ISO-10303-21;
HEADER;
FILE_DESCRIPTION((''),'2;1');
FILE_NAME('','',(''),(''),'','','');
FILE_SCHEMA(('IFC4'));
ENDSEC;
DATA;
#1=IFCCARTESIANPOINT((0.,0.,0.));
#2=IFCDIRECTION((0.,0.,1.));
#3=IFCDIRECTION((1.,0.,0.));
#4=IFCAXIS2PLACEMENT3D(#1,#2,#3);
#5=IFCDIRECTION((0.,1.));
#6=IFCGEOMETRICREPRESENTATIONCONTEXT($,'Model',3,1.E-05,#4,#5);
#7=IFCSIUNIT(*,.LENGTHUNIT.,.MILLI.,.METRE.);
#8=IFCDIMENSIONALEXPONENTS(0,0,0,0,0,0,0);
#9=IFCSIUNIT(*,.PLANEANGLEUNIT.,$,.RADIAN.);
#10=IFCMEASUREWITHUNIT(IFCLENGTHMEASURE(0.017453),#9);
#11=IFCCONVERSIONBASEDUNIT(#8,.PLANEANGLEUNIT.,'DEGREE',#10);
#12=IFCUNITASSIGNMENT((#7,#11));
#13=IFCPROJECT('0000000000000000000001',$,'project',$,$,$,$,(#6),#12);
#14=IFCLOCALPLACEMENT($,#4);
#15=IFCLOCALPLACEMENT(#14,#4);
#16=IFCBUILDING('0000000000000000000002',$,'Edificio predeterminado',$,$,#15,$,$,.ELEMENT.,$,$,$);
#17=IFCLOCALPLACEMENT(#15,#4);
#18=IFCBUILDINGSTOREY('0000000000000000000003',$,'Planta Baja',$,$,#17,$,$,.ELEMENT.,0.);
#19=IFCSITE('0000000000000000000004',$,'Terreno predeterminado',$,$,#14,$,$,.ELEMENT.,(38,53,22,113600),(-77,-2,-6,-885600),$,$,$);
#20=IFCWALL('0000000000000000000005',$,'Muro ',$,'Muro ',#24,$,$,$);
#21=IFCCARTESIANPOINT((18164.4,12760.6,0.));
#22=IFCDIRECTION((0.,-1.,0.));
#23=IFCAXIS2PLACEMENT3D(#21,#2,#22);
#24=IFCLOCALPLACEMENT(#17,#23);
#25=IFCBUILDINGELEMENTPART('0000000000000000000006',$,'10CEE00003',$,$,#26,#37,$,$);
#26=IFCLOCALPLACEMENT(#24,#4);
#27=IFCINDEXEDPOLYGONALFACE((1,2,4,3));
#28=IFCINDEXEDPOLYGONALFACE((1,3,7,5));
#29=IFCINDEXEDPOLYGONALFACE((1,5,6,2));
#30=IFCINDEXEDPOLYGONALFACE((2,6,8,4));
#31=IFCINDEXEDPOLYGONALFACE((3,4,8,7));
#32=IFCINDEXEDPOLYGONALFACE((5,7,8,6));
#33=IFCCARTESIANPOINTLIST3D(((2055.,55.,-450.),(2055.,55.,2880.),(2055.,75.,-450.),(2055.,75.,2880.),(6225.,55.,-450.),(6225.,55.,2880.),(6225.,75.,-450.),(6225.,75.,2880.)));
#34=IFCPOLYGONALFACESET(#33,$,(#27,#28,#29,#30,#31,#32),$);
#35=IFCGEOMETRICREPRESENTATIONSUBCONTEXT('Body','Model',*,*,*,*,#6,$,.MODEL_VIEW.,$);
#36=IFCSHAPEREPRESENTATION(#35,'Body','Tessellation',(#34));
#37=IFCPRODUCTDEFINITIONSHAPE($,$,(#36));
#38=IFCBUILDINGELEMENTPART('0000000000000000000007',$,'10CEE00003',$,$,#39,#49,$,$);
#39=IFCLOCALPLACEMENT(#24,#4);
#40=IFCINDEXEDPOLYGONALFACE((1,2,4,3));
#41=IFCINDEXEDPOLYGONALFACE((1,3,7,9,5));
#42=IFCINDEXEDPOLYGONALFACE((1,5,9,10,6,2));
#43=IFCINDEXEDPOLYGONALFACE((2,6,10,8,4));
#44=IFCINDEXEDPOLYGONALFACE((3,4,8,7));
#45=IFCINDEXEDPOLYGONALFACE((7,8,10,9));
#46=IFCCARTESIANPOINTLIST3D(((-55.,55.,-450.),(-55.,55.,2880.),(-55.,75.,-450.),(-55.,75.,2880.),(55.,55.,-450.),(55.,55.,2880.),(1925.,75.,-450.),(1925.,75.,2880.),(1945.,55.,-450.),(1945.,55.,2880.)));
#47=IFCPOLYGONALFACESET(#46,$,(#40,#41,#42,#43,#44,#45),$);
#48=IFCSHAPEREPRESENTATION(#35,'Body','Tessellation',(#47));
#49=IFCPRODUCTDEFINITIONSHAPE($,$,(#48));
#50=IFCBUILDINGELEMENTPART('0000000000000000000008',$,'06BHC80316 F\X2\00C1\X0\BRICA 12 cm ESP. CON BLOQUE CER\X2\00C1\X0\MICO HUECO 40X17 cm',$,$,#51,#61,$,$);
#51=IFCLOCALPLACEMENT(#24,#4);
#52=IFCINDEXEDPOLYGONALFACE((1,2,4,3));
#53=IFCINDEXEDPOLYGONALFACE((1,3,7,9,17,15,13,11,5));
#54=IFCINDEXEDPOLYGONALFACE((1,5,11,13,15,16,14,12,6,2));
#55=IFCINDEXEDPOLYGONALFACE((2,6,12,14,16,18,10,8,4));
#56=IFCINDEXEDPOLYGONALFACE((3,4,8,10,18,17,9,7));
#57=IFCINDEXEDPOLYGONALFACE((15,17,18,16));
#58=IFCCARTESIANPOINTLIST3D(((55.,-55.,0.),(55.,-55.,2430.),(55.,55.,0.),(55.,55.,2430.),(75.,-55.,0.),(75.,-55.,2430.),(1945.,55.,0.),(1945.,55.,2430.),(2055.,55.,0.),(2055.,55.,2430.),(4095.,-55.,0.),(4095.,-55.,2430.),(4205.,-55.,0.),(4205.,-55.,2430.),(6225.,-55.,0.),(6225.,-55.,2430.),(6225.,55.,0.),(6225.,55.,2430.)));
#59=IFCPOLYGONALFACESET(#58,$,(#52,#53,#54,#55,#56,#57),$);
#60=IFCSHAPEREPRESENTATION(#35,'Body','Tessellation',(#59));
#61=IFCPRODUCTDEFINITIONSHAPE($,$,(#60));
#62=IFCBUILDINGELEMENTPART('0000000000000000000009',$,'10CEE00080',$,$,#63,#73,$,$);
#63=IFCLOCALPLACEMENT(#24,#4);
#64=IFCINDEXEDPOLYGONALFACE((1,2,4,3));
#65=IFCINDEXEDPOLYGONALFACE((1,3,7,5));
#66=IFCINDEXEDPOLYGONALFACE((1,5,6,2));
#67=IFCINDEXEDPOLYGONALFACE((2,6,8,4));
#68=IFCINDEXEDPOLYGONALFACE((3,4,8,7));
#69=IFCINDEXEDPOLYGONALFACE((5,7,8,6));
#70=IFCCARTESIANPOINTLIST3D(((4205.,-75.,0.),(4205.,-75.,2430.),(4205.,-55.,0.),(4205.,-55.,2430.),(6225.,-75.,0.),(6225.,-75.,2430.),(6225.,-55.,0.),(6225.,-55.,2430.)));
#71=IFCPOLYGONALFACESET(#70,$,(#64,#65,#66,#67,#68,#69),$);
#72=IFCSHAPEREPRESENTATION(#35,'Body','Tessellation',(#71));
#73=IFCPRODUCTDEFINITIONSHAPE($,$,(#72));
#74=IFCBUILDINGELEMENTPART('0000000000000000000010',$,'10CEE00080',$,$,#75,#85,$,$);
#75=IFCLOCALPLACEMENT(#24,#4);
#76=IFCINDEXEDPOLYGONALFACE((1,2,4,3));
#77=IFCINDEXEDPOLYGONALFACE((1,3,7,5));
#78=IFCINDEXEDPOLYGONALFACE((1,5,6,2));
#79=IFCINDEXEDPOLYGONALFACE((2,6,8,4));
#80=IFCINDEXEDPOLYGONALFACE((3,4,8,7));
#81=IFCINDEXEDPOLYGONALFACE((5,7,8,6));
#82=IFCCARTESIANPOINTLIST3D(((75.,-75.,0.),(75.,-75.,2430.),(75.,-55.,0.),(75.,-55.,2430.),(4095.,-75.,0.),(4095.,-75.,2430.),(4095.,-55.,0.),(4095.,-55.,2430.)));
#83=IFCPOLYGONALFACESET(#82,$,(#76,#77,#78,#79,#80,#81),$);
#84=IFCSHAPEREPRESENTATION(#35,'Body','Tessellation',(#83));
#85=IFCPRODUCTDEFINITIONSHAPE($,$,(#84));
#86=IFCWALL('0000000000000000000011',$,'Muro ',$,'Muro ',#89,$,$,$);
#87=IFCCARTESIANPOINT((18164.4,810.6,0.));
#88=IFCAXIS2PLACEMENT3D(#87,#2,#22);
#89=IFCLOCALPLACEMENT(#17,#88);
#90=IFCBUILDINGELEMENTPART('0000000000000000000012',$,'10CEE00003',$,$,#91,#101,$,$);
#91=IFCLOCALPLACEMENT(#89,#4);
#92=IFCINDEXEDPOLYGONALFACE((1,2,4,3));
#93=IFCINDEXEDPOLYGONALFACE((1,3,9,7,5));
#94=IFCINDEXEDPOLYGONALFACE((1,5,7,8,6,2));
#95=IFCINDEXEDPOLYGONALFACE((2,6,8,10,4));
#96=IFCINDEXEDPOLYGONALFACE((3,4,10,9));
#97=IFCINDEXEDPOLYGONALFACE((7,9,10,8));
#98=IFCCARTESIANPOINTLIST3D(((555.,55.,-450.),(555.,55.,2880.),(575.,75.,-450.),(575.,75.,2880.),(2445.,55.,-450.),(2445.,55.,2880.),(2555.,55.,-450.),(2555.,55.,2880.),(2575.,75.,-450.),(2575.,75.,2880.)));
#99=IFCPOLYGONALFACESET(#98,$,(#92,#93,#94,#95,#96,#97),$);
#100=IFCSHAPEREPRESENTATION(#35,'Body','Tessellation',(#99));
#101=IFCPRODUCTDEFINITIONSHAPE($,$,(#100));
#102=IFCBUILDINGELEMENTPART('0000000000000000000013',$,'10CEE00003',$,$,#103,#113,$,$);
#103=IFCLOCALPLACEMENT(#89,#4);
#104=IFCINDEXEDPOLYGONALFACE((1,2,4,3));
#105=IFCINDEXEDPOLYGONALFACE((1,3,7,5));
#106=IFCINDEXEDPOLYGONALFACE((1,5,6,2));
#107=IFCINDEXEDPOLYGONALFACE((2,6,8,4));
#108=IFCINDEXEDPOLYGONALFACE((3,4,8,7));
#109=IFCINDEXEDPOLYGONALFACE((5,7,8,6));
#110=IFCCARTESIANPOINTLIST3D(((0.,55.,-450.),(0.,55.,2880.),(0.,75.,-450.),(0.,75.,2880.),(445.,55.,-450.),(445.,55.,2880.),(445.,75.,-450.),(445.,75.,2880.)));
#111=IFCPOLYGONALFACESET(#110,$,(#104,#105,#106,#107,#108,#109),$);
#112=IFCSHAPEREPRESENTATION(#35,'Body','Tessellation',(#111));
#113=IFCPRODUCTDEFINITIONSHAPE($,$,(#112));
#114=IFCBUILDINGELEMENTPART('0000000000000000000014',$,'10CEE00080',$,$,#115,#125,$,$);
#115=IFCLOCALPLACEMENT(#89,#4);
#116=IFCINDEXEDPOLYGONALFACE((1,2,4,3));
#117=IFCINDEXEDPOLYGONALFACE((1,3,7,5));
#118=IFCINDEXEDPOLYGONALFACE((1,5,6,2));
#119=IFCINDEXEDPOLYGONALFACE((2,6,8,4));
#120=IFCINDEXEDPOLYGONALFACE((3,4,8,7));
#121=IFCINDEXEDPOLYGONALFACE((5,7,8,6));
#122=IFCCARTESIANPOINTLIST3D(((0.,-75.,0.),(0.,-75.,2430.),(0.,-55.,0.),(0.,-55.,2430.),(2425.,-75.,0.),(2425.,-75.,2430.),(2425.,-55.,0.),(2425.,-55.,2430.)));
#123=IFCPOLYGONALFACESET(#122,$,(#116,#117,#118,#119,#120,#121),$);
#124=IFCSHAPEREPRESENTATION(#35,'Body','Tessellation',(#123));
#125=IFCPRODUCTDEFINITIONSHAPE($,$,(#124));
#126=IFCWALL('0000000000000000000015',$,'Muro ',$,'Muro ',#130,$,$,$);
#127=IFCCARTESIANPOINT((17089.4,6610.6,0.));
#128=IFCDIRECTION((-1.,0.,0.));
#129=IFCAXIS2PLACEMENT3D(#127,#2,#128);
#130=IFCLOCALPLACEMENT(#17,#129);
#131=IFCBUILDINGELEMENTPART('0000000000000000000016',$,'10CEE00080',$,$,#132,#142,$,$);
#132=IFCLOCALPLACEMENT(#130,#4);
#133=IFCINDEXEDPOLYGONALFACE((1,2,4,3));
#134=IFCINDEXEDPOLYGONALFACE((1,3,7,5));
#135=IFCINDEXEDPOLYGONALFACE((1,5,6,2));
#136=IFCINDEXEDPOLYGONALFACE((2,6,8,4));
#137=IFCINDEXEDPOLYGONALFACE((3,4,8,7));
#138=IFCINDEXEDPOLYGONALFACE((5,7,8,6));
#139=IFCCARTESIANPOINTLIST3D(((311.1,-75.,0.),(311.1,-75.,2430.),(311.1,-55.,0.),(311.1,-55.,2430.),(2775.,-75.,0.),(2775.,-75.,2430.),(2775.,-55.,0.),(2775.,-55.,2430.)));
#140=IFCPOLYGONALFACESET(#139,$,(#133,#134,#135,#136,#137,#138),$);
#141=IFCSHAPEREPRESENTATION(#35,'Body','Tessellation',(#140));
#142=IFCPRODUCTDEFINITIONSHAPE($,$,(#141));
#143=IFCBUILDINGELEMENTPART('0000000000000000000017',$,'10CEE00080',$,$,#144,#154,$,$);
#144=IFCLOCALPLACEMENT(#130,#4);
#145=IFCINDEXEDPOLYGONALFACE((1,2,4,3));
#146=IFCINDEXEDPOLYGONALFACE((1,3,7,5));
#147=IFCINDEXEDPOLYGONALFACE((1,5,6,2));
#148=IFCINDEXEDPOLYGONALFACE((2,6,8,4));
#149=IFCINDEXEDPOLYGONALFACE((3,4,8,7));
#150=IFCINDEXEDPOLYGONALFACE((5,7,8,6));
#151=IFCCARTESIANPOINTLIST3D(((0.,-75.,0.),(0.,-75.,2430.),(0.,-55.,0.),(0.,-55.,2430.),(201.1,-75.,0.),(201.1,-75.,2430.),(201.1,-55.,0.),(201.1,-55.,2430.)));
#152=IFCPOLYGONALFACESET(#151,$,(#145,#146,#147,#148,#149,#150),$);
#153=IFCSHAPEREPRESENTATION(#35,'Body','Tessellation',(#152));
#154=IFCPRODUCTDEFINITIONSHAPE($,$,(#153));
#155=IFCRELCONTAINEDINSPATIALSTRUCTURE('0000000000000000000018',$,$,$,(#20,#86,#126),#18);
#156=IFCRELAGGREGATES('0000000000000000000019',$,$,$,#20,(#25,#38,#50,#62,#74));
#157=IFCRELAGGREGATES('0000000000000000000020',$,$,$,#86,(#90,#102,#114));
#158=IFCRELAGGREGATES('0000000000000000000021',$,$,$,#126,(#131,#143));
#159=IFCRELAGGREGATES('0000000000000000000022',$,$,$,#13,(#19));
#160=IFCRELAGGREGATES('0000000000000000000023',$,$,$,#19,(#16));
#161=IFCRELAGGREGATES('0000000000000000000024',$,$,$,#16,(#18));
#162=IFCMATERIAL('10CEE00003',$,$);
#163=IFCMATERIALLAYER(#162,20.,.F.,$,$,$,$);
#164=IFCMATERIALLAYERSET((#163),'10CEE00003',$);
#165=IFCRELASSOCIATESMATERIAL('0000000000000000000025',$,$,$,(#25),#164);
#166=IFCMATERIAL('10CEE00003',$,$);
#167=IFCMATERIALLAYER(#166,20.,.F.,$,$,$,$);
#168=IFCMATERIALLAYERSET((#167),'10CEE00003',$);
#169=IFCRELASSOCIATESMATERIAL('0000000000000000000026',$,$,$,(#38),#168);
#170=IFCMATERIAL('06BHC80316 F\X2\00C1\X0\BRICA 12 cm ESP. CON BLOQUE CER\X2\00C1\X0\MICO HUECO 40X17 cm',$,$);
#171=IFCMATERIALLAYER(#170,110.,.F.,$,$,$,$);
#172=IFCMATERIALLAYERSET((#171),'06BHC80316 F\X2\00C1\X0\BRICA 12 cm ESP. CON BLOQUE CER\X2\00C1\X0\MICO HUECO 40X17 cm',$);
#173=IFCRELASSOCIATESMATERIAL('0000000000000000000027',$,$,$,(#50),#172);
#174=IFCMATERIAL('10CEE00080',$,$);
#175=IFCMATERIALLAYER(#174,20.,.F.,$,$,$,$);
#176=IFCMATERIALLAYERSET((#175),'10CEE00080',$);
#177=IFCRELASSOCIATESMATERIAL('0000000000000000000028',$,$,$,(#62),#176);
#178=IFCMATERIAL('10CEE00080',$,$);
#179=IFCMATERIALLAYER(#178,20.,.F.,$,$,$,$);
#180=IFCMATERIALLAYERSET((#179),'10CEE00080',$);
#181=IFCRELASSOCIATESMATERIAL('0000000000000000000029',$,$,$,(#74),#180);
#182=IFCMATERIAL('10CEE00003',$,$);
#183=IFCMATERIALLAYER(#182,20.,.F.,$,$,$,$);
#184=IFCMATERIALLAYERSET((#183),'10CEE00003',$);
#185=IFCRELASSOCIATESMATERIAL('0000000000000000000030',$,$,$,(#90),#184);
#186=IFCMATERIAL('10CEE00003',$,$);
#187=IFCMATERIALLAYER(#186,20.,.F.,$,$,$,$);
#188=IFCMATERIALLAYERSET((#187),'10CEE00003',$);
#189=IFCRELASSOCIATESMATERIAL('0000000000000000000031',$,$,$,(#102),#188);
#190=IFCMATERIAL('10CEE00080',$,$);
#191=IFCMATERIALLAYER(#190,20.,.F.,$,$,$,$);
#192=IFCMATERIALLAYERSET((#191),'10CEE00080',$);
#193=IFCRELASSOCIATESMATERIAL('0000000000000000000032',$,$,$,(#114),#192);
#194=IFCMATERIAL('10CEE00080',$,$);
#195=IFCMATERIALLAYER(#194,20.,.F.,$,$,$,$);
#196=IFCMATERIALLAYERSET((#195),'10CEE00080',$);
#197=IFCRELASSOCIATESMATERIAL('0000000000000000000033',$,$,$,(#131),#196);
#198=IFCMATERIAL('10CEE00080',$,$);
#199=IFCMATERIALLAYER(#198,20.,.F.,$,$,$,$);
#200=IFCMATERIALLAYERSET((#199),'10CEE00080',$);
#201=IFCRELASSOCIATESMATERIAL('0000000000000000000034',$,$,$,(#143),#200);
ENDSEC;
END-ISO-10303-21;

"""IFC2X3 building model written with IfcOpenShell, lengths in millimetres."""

from ifc_helpers import new_model, entity, si_unit, converted_unit, direction, frame, origin_with_axes, place, context, subcontext, project, spatial, polyline, outline, extrude, material, layer, layer_set, layer_usage, element, aggregate, save


model = new_model("IFC2X3")

# Units and contexts
model_context = context("Model", 3, precision=1e-05, world=origin_with_axes(), true_north=direction((0.0, 1.0)))
body_context = subcontext(model_context, "Body", "Model", "MODEL_VIEW")
ifc_project = project(units=[si_unit("LENGTHUNIT", "METRE", prefix="MILLI"), converted_unit("PLANEANGLEUNIT", "DEGREE", entity("IfcLengthMeasure", 0.017453), si_unit("PLANEANGLEUNIT", "RADIAN"), dimensions=[0, 0, 0, 0, 0, 0, 0])], contexts=[model_context])

# Site, building, storey
site_placement = place(None, origin_with_axes())
site = spatial("IfcSite", under=ifc_project, at=site_placement, Name="Terreno predeterminado", CompositionType="ELEMENT", RefLatitude=(38, 53, 22, 113600), RefLongitude=(-77, -2, -6, -885600))
building_placement = place(site_placement, origin_with_axes())
building = spatial("IfcBuilding", under=site, at=building_placement, Name="Edificio predeterminado", CompositionType="ELEMENT")
storey_placement = place(building_placement, origin_with_axes())
storey = spatial("IfcBuildingStorey", under=building, at=storey_placement, Name="Planta Baja", CompositionType="ELEMENT", Elevation=0.0)

# Walls, building element parts
wall_1_placement = place(storey_placement, frame((18164.4, 12760.6, 0.0), z_axis=(0.0, 0.0, 1.0), x_axis=(0.0, -1.0, 0.0)))
wall_1 = element("IfcWall", 1, at=wall_1_placement, inside=storey, Name="Muro ", ObjectType="Muro ")
ifc_material_1 = material(Name="10CEE00003")
ifc_layer_1 = layer(ifc_material_1, 20.0, ventilated=False)
ifc_layer_set_1 = layer_set([ifc_layer_1], Name="10CEE00003")
ifc_layer_usage_1 = layer_usage(ifc_layer_set_1, "AXIS2", "NEGATIVE", -75.0)
building_element_part_1_placement = place(wall_1_placement, origin_with_axes())
building_element_part_1 = element("IfcBuildingElementPart", 2, at=building_element_part_1_placement, material=ifc_layer_usage_1, Name="10CEE00003", context=body_context, shape_type="SweptSolid", body=[
    extrude(outline(polyline([(6225.0, 75.0), (6225.0, 55.0), (2055.0, 55.0), (2055.0, 75.0), (6225.0, 75.0)])), frame((0.0, 0.0, -450.0), z_axis=(0.0, 0.0, 1.0), x_axis=(1.0, 0.0, 0.0)), (0.0, 0.0, 1.0), 3330.0),
])
ifc_material_2 = material(Name="10CEE00003")
ifc_layer_2 = layer(ifc_material_2, 20.0, ventilated=False)
ifc_layer_set_2 = layer_set([ifc_layer_2], Name="10CEE00003")
ifc_layer_usage_2 = layer_usage(ifc_layer_set_2, "AXIS2", "NEGATIVE", -75.0)
building_element_part_2_placement = place(wall_1_placement, origin_with_axes())
building_element_part_2 = element("IfcBuildingElementPart", 3, at=building_element_part_2_placement, material=ifc_layer_usage_2, Name="10CEE00003", context=body_context, shape_type="SweptSolid", body=[
    extrude(outline(polyline([(1925.0, 75.0), (1945.0, 55.0), (55.0, 55.0), (-55.0, 55.0), (-55.0, 75.0), (1925.0, 75.0)])), frame((0.0, 0.0, -450.0), z_axis=(0.0, 0.0, 1.0), x_axis=(1.0, 0.0, 0.0)), (0.0, 0.0, 1.0), 3330.0),
])
ifc_material_3 = material(Name="06BHC80316 FÁBRICA 12 cm ESP. CON BLOQUE CERÁMICO HUECO 40X17 cm")
ifc_layer_3 = layer(ifc_material_3, 110.0, ventilated=False)
ifc_layer_set_3 = layer_set([ifc_layer_3], Name="06BHC80316 FÁBRICA 12 cm ESP. CON BLOQUE CERÁMICO HUECO 40X17 cm")
ifc_layer_usage_3 = layer_usage(ifc_layer_set_3, "AXIS2", "NEGATIVE", -55.0)
building_element_part_3_placement = place(wall_1_placement, origin_with_axes())
building_element_part_3 = element("IfcBuildingElementPart", 4, at=building_element_part_3_placement, material=ifc_layer_usage_3, Name="06BHC80316 FÁBRICA 12 cm ESP. CON BLOQUE CERÁMICO HUECO 40X17 cm", context=body_context, shape_type="SweptSolid", body=[
    extrude(outline(polyline([(6225.0, 55.0), (6225.0, -55.0), (4205.0, -55.0), (4095.0, -55.0), (75.0, -55.0), (55.0, -55.0), (55.0, 55.0), (1945.0, 55.0), (2055.0, 55.0), (6225.0, 55.0)])), origin_with_axes(), (0.0, 0.0, 1.0), 2430.0),
])
ifc_material_4 = material(Name="10CEE00080")
ifc_layer_4 = layer(ifc_material_4, 20.0, ventilated=False)
ifc_layer_set_4 = layer_set([ifc_layer_4], Name="10CEE00080")
ifc_layer_usage_4 = layer_usage(ifc_layer_set_4, "AXIS2", "NEGATIVE", 55.0)
building_element_part_4_placement = place(wall_1_placement, origin_with_axes())
building_element_part_4 = element("IfcBuildingElementPart", 5, at=building_element_part_4_placement, material=ifc_layer_usage_4, Name="10CEE00080", context=body_context, shape_type="SweptSolid", body=[
    extrude(outline(polyline([(6225.0, -55.0), (6225.0, -75.0), (4205.0, -75.0), (4205.0, -55.0), (6225.0, -55.0)])), origin_with_axes(), (0.0, 0.0, 1.0), 2430.0),
])
ifc_material_5 = material(Name="10CEE00080")
ifc_layer_5 = layer(ifc_material_5, 20.0, ventilated=False)
ifc_layer_set_5 = layer_set([ifc_layer_5], Name="10CEE00080")
ifc_layer_usage_5 = layer_usage(ifc_layer_set_5, "AXIS2", "NEGATIVE", 55.0)
building_element_part_5_placement = place(wall_1_placement, origin_with_axes())
building_element_part_5 = element("IfcBuildingElementPart", 6, at=building_element_part_5_placement, material=ifc_layer_usage_5, Name="10CEE00080", context=body_context, shape_type="SweptSolid", body=[
    extrude(outline(polyline([(4095.0, -55.0), (4095.0, -75.0), (75.0, -75.0), (75.0, -55.0), (4095.0, -55.0)])), origin_with_axes(), (0.0, 0.0, 1.0), 2430.0),
])
aggregate(wall_1, [building_element_part_1, building_element_part_2, building_element_part_3, building_element_part_4, building_element_part_5])
wall_2_placement = place(storey_placement, frame((18164.4, 810.6, 0.0), z_axis=(0.0, 0.0, 1.0), x_axis=(0.0, -1.0, 0.0)))
wall_2 = element("IfcWall", 7, at=wall_2_placement, inside=storey, Name="Muro ", ObjectType="Muro ")
ifc_material_6 = material(Name="10CEE00003")
ifc_layer_6 = layer(ifc_material_6, 20.0, ventilated=False)
ifc_layer_set_6 = layer_set([ifc_layer_6], Name="10CEE00003")
ifc_layer_usage_6 = layer_usage(ifc_layer_set_6, "AXIS2", "NEGATIVE", -75.0)
building_element_part_6_placement = place(wall_2_placement, origin_with_axes())
building_element_part_6 = element("IfcBuildingElementPart", 8, at=building_element_part_6_placement, material=ifc_layer_usage_6, Name="10CEE00003", context=body_context, shape_type="SweptSolid", body=[
    extrude(outline(polyline([(2575.0, 75.0), (2555.0, 55.0), (2445.0, 55.0), (555.0, 55.0), (575.0, 75.0), (2575.0, 75.0)])), frame((0.0, 0.0, -450.0), z_axis=(0.0, 0.0, 1.0), x_axis=(1.0, 0.0, 0.0)), (0.0, 0.0, 1.0), 3330.0),
])
ifc_material_7 = material(Name="10CEE00003")
ifc_layer_7 = layer(ifc_material_7, 20.0, ventilated=False)
ifc_layer_set_7 = layer_set([ifc_layer_7], Name="10CEE00003")
ifc_layer_usage_7 = layer_usage(ifc_layer_set_7, "AXIS2", "NEGATIVE", -75.0)
building_element_part_7_placement = place(wall_2_placement, origin_with_axes())
building_element_part_7 = element("IfcBuildingElementPart", 9, at=building_element_part_7_placement, material=ifc_layer_usage_7, Name="10CEE00003", context=body_context, shape_type="SweptSolid", body=[
    extrude(outline(polyline([(445.0, 75.0), (445.0, 55.0), (0.0, 55.0), (0.0, 75.0), (445.0, 75.0)])), frame((0.0, 0.0, -450.0), z_axis=(0.0, 0.0, 1.0), x_axis=(1.0, 0.0, 0.0)), (0.0, 0.0, 1.0), 3330.0),
])
ifc_material_8 = material(Name="10CEE00080")
ifc_layer_8 = layer(ifc_material_8, 20.0, ventilated=False)
ifc_layer_set_8 = layer_set([ifc_layer_8], Name="10CEE00080")
ifc_layer_usage_8 = layer_usage(ifc_layer_set_8, "AXIS2", "NEGATIVE", 55.0)
building_element_part_8_placement = place(wall_2_placement, origin_with_axes())
building_element_part_8 = element("IfcBuildingElementPart", 10, at=building_element_part_8_placement, material=ifc_layer_usage_8, Name="10CEE00080", context=body_context, shape_type="SweptSolid", body=[
    extrude(outline(polyline([(2425.0, -55.0), (2425.0, -75.0), (0.0, -75.0), (0.0, -55.0), (2425.0, -55.0)])), origin_with_axes(), (0.0, 0.0, 1.0), 2430.0),
])
aggregate(wall_2, [building_element_part_6, building_element_part_7, building_element_part_8])
wall_3_placement = place(storey_placement, frame((17089.4, 6610.6, 0.0), z_axis=(0.0, 0.0, 1.0), x_axis=(-1.0, 0.0, 0.0)))
wall_3 = element("IfcWall", 11, at=wall_3_placement, inside=storey, Name="Muro ", ObjectType="Muro ")
ifc_material_9 = material(Name="10CEE00080")
ifc_layer_9 = layer(ifc_material_9, 20.0, ventilated=False)
ifc_layer_set_9 = layer_set([ifc_layer_9], Name="10CEE00080")
ifc_layer_usage_9 = layer_usage(ifc_layer_set_9, "AXIS2", "NEGATIVE", 55.0)
building_element_part_9_placement = place(wall_3_placement, origin_with_axes())
building_element_part_9 = element("IfcBuildingElementPart", 12, at=building_element_part_9_placement, material=ifc_layer_usage_9, Name="10CEE00080", context=body_context, shape_type="SweptSolid", body=[
    extrude(outline(polyline([(2775.0, -55.0), (2775.0, -75.0), (311.1, -75.0), (311.1, -55.0), (2775.0, -55.0)])), origin_with_axes(), (0.0, 0.0, 1.0), 2430.0),
])
ifc_material_10 = material(Name="10CEE00080")
ifc_layer_10 = layer(ifc_material_10, 20.0, ventilated=False)
ifc_layer_set_10 = layer_set([ifc_layer_10], Name="10CEE00080")
ifc_layer_usage_10 = layer_usage(ifc_layer_set_10, "AXIS2", "NEGATIVE", 55.0)
building_element_part_10_placement = place(wall_3_placement, origin_with_axes())
building_element_part_10 = element("IfcBuildingElementPart", 13, at=building_element_part_10_placement, material=ifc_layer_usage_10, Name="10CEE00080", context=body_context, shape_type="SweptSolid", body=[
    extrude(outline(polyline([(201.1, -55.0), (201.1, -75.0), (0.0, -75.0), (0.0, -55.0), (201.1, -55.0)])), origin_with_axes(), (0.0, 0.0, 1.0), 2430.0),
])
aggregate(wall_3, [building_element_part_9, building_element_part_10])

save(model, "model.ifc")
